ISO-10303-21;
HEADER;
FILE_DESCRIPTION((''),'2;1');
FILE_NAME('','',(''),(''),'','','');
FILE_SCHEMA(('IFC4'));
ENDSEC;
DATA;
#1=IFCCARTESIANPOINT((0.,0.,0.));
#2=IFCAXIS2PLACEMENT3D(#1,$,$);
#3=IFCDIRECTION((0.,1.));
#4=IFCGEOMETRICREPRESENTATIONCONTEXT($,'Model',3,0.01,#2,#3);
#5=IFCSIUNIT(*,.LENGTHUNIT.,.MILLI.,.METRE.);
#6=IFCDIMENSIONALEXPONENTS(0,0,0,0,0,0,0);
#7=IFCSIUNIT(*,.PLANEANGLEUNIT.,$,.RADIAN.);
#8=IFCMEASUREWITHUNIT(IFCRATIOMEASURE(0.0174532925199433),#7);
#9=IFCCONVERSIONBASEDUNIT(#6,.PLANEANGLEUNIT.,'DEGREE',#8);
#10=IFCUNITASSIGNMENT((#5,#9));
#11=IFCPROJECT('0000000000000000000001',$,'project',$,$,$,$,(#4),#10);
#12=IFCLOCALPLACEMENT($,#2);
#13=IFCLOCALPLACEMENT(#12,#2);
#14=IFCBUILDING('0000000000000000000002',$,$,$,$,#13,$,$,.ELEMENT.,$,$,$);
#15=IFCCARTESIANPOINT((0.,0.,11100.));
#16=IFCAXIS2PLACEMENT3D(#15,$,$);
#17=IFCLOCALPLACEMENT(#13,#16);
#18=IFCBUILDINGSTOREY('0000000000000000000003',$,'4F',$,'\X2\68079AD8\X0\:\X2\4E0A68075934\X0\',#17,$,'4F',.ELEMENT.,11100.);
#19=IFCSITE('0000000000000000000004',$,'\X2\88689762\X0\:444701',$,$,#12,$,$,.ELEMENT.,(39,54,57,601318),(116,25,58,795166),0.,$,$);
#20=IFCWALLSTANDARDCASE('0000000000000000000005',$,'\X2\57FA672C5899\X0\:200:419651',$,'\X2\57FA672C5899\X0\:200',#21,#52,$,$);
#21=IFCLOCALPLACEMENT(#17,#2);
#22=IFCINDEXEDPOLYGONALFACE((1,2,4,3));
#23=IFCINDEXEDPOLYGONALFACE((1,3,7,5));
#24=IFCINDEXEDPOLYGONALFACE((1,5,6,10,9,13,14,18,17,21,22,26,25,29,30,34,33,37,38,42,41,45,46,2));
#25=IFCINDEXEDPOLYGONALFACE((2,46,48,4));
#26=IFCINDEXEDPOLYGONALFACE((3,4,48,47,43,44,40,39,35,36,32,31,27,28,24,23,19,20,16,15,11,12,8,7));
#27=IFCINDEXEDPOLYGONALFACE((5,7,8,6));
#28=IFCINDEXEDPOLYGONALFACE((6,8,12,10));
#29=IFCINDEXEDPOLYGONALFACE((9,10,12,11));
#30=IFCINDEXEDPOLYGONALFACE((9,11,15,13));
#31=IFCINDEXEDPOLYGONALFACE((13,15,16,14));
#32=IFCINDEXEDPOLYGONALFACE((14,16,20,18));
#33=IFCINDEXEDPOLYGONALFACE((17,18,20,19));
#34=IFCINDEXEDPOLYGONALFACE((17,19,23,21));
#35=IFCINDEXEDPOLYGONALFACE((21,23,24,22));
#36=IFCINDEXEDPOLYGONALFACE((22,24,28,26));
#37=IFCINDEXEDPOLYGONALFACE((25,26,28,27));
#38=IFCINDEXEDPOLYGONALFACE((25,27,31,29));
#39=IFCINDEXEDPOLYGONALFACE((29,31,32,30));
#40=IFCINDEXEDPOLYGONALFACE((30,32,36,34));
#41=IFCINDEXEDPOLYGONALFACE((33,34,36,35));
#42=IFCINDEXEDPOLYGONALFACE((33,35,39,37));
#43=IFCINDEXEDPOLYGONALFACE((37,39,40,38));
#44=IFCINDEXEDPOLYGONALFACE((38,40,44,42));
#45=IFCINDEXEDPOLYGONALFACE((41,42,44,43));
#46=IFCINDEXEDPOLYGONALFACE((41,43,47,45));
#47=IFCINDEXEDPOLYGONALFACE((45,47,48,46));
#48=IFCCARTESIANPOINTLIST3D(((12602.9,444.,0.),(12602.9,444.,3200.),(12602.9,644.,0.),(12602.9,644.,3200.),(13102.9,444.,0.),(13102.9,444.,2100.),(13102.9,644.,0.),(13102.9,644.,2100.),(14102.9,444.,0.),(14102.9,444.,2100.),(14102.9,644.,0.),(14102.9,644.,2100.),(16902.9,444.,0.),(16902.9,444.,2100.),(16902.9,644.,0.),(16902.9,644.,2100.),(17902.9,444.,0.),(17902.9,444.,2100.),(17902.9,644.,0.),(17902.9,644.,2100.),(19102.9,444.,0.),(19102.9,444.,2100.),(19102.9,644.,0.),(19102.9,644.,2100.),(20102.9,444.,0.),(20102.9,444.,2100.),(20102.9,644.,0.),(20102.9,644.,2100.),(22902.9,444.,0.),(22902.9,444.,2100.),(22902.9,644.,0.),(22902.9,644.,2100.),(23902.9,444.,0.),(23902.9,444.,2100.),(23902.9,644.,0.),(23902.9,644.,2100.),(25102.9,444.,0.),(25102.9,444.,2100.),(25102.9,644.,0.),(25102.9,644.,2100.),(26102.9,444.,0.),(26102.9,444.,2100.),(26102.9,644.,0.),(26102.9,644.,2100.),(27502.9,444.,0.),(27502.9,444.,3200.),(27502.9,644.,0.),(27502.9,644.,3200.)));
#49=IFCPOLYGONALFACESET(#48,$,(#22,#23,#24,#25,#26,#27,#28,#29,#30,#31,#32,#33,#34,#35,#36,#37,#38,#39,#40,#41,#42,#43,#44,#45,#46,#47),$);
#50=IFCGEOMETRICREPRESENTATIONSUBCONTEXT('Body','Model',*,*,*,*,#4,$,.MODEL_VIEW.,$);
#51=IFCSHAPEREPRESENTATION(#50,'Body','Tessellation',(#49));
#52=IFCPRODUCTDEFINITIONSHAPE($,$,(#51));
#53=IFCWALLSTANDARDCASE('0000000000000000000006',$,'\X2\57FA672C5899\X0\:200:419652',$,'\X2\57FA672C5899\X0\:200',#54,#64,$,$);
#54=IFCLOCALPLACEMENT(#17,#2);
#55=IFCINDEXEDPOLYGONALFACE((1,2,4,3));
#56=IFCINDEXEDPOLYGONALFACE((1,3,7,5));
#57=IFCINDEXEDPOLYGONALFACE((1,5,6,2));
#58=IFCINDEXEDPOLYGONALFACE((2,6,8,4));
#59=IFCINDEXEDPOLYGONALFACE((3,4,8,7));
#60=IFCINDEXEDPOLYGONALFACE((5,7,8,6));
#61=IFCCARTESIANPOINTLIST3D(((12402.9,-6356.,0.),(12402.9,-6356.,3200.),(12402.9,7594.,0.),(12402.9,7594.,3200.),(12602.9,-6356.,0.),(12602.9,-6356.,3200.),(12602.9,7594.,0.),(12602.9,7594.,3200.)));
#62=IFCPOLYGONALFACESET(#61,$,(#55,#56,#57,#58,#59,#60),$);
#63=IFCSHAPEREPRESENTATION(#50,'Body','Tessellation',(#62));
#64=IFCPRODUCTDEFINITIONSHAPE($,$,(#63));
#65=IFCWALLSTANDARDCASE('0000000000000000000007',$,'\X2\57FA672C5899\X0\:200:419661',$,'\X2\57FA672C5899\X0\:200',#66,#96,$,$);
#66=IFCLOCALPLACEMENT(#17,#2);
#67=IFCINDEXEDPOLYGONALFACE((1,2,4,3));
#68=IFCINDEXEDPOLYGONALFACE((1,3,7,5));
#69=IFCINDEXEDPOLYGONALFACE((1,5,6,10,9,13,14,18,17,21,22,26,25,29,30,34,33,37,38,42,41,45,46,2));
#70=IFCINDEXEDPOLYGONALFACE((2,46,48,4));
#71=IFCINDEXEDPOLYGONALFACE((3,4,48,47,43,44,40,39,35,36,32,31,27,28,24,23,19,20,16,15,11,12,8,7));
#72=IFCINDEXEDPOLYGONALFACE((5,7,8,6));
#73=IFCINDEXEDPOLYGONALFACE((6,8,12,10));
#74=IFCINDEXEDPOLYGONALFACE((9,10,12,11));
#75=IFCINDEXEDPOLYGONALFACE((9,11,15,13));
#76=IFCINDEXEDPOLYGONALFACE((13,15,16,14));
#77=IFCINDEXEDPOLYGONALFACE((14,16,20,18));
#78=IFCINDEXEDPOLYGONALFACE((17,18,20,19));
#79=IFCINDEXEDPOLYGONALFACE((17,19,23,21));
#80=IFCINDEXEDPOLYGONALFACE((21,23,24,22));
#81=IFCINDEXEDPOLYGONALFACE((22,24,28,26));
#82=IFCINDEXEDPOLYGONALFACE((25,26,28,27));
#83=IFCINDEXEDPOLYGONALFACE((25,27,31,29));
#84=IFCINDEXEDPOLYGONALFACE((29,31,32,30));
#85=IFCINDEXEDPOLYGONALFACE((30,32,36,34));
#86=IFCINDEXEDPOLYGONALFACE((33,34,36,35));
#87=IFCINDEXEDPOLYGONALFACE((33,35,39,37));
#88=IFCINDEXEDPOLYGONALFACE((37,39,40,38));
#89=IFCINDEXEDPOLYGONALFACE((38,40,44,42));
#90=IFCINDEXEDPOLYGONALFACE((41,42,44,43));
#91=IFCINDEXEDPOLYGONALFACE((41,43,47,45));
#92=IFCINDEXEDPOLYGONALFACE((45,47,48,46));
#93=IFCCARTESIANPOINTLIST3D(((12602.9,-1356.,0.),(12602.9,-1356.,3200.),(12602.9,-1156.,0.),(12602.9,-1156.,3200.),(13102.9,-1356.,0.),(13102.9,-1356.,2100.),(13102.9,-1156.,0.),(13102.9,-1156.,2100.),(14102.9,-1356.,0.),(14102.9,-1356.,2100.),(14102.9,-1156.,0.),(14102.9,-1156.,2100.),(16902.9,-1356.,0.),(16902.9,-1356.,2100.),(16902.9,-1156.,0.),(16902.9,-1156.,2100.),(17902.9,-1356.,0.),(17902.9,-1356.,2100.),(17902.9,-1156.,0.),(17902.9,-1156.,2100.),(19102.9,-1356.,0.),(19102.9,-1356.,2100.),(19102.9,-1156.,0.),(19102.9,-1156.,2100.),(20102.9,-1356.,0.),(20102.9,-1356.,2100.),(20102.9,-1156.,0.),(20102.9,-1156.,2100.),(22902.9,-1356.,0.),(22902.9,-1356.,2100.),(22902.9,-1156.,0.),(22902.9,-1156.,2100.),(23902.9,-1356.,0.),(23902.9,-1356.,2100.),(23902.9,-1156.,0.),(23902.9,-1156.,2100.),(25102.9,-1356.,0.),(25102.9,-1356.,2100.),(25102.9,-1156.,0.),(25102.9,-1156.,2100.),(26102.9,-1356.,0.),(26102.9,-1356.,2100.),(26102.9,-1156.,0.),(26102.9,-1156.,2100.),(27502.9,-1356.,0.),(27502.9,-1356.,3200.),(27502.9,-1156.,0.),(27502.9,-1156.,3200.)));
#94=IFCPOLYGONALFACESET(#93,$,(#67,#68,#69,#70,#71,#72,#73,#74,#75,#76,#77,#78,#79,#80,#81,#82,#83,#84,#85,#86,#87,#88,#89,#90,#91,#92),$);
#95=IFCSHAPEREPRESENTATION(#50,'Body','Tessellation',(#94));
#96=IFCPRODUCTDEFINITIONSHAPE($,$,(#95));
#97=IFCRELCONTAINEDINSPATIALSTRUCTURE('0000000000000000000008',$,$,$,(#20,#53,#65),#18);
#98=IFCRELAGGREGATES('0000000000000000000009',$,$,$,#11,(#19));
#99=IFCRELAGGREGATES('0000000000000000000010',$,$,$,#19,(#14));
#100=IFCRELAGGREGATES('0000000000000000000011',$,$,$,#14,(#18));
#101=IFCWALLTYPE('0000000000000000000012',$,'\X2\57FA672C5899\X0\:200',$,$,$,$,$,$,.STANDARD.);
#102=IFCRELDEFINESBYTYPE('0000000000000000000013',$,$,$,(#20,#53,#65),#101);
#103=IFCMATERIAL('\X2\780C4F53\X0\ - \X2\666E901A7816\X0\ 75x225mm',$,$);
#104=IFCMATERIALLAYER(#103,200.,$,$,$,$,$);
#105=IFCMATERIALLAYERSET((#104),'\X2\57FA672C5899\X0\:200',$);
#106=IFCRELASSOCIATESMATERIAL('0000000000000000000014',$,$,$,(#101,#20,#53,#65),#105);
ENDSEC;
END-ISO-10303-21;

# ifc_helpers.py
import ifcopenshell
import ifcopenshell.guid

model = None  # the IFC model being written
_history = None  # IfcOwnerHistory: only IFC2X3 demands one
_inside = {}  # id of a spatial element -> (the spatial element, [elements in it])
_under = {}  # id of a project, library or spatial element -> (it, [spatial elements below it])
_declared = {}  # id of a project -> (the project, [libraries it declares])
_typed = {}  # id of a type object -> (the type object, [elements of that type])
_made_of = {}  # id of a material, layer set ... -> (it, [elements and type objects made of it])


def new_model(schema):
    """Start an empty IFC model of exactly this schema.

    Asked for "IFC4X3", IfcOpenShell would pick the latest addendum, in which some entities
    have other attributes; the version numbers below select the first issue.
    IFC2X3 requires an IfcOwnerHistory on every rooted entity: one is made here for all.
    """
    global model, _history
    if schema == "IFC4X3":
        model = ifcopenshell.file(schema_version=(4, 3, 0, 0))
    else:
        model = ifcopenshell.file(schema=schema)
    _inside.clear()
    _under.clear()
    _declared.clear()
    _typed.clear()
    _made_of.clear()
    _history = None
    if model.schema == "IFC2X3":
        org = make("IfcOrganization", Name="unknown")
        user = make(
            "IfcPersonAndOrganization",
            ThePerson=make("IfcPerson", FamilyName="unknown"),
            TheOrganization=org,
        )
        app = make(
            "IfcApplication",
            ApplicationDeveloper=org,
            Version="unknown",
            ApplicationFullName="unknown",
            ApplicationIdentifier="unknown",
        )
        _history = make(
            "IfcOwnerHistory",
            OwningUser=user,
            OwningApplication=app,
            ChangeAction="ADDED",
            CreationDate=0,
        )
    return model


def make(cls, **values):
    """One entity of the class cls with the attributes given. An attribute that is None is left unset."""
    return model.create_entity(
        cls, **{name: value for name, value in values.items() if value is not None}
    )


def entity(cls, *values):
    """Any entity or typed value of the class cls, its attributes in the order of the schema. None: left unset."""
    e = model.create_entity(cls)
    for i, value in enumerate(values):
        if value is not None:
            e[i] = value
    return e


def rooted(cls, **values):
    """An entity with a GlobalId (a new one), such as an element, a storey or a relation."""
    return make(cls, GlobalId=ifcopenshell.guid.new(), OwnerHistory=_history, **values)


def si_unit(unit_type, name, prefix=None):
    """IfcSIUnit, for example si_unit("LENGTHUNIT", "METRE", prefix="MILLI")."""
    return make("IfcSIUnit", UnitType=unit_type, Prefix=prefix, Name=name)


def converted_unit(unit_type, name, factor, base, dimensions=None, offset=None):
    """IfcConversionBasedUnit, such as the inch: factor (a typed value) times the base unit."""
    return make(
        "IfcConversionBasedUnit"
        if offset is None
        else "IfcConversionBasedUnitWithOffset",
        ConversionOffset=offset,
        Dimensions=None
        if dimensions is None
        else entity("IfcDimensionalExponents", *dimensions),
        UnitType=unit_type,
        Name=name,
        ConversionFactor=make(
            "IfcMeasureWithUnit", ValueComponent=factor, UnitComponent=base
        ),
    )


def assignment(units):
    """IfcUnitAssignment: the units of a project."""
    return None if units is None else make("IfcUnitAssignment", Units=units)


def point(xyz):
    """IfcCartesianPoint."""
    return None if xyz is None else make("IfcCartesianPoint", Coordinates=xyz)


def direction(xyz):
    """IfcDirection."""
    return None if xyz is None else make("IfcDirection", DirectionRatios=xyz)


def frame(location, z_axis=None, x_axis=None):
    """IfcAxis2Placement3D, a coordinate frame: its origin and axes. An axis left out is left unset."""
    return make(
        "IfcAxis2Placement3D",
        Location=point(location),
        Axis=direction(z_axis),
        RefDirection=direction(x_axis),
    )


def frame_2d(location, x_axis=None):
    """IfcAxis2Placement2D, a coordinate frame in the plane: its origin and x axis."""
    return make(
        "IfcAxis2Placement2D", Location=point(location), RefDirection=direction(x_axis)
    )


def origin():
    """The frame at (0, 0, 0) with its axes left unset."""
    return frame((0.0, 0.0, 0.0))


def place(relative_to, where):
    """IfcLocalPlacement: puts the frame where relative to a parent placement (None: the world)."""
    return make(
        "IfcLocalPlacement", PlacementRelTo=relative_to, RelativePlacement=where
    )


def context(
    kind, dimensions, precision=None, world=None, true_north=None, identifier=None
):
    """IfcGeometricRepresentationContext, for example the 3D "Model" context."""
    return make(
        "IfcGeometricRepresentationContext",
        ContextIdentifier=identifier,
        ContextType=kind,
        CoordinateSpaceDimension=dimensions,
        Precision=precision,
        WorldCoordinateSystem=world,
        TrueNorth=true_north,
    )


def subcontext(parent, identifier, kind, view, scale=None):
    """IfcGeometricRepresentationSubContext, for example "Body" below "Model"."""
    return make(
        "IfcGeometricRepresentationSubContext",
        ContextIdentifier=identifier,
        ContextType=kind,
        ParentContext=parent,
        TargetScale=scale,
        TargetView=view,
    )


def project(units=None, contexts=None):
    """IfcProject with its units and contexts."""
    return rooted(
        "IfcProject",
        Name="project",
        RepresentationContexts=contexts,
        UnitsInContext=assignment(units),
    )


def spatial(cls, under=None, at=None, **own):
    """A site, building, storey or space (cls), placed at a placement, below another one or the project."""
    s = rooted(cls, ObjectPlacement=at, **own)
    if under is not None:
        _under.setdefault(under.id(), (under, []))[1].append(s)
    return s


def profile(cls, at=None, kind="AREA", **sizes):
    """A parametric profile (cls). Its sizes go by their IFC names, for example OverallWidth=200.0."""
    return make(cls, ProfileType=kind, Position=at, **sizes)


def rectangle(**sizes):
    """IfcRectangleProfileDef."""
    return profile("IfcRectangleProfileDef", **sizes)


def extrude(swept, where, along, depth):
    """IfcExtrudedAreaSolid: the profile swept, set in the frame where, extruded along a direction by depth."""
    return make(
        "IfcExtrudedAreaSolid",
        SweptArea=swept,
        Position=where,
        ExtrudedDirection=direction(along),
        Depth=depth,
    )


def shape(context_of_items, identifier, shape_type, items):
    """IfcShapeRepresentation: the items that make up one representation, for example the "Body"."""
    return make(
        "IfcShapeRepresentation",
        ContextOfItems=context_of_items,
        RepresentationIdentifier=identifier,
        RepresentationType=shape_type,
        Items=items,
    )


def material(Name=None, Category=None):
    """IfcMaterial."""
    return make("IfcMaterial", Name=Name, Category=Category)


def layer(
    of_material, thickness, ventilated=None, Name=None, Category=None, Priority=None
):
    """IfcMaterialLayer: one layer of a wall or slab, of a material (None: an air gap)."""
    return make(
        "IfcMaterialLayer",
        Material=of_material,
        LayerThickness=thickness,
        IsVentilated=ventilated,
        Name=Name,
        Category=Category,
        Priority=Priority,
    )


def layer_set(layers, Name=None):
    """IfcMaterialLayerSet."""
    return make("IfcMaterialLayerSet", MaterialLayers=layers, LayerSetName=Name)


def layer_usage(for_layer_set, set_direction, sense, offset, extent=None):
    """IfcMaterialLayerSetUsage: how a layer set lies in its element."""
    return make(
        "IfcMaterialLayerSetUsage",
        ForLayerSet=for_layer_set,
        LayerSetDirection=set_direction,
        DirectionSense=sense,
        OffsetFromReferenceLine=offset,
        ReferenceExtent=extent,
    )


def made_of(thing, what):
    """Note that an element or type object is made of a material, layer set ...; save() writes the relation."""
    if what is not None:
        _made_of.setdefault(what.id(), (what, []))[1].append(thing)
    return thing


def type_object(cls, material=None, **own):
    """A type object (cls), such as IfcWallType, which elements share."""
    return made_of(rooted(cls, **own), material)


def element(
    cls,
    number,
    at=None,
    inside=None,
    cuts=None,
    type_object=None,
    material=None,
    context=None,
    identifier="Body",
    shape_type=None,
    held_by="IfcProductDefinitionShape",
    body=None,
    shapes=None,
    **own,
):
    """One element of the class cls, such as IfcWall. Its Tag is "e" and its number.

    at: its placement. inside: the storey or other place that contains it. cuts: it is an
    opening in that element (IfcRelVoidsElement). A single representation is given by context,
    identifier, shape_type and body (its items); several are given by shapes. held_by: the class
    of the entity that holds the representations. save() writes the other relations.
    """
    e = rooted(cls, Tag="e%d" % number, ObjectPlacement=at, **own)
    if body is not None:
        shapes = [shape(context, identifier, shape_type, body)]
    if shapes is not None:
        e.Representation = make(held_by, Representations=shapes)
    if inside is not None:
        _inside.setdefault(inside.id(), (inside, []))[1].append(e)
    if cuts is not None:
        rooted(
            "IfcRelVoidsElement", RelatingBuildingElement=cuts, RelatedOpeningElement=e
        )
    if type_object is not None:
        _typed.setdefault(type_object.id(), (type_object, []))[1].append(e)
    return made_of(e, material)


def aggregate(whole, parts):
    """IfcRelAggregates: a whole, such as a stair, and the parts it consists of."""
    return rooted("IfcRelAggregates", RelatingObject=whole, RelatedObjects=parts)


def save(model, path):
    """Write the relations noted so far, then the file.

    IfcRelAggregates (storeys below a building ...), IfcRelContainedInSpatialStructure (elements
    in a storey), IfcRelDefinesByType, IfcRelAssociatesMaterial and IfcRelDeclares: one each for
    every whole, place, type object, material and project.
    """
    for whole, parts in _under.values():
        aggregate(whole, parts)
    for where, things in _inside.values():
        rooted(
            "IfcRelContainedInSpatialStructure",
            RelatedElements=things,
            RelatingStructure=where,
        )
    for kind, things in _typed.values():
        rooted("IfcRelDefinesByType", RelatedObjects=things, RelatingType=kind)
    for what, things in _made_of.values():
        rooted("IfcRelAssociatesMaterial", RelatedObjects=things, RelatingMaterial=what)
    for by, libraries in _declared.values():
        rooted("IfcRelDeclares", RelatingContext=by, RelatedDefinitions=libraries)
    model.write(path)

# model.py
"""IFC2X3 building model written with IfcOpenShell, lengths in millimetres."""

from ifc_helpers import new_model, entity, si_unit, converted_unit, direction, frame, frame_2d, origin, place, context, subcontext, project, spatial, rectangle, extrude, material, layer, layer_set, layer_usage, type_object, element, save


model = new_model("IFC2X3")

# Units and contexts
model_context = context("Model", 3, precision=0.01, world=origin(), true_north=direction((0.0, 1.0)))
body_context = subcontext(model_context, "Body", "Model", "MODEL_VIEW")
ifc_project = project(units=[si_unit("LENGTHUNIT", "METRE", prefix="MILLI"), converted_unit("PLANEANGLEUNIT", "DEGREE", entity("IfcRatioMeasure", 0.0174532925199433), si_unit("PLANEANGLEUNIT", "RADIAN"), dimensions=[0, 0, 0, 0, 0, 0, 0])], contexts=[model_context])

# Site, building, storey
site_placement = place(None, origin())
site = spatial("IfcSite", under=ifc_project, at=site_placement, Name="表面:444701", CompositionType="ELEMENT", RefLatitude=(39, 54, 57, 601318), RefLongitude=(116, 25, 58, 795166), RefElevation=0.0)
building_placement = place(site_placement, origin())
building = spatial("IfcBuilding", under=site, at=building_placement, CompositionType="ELEMENT")
storey_placement = place(building_placement, frame((0.0, 0.0, 11100.0)))
storey = spatial("IfcBuildingStorey", under=building, at=storey_placement, Name="4F", ObjectType="标高:上标头", LongName="4F", CompositionType="ELEMENT", Elevation=11100.0)

# Shared definitions
ifc_material_1 = material(Name="砌体 - 普通砖 75x225mm")

# Wall, openings
ifc_layer_1 = layer(ifc_material_1, 200.0)
ifc_layer_set_1 = layer_set([ifc_layer_1], Name="基本墙:200")
ifc_layer_usage_1 = layer_usage(ifc_layer_set_1, "AXIS2", "NEGATIVE", 100.0)
wall_type_1 = type_object("IfcWallType", Name="基本墙:200", PredefinedType="STANDARD", material=ifc_layer_set_1)
wall_1_placement = place(storey_placement, frame((12602.9, 544.0, 0.0)))
wall_1 = element("IfcWallStandardCase", 1, at=wall_1_placement, inside=storey, type_object=wall_type_1, material=ifc_layer_usage_1, Name="基本墙:200:419651", ObjectType="基本墙:200", context=body_context, shape_type="SweptSolid", body=[
    extrude(rectangle(XDim=14900.0, YDim=200.0, at=frame_2d((7450.0, 0.0), x_axis=(-1.0, 0.0))), origin(), (0.0, 0.0, 1.0), 3200.0),
])
opening_1_placement = place(wall_1_placement, frame((12500.0, -100.0, 0.0)))
element("IfcOpeningElement", 2, at=opening_1_placement, cuts=wall_1, ObjectType="Opening", context=body_context, shape_type="SweptSolid", body=[
    extrude(rectangle(XDim=2100.0, YDim=1000.0, at=frame_2d((1050.0, 500.0), x_axis=(1.0, 0.0))), frame((0.0, 0.0, 0.0), z_axis=(0.0, 1.0, 0.0), x_axis=(0.0, 0.0, 1.0)), (0.0, 0.0, 1.0), 200.0),
])
opening_2_placement = place(wall_1_placement, frame((10300.0, -100.0, 0.0)))
element("IfcOpeningElement", 3, at=opening_2_placement, cuts=wall_1, ObjectType="Opening", context=body_context, shape_type="SweptSolid", body=[
    extrude(rectangle(XDim=2100.0, YDim=1000.0, at=frame_2d((1050.0, 500.0), x_axis=(1.0, 0.0))), frame((0.0, 0.0, 0.0), z_axis=(0.0, 1.0, 0.0), x_axis=(0.0, 0.0, 1.0)), (0.0, 0.0, 1.0), 200.0),
])
opening_3_placement = place(wall_1_placement, frame((6500.0, -100.0, 0.0)))
element("IfcOpeningElement", 4, at=opening_3_placement, cuts=wall_1, ObjectType="Opening", context=body_context, shape_type="SweptSolid", body=[
    extrude(rectangle(XDim=2100.0, YDim=1000.0, at=frame_2d((1050.0, 500.0), x_axis=(1.0, 0.0))), frame((0.0, 0.0, 0.0), z_axis=(0.0, 1.0, 0.0), x_axis=(0.0, 0.0, 1.0)), (0.0, 0.0, 1.0), 200.0),
])
opening_4_placement = place(wall_1_placement, frame((4300.0, -100.0, 0.0)))
element("IfcOpeningElement", 5, at=opening_4_placement, cuts=wall_1, ObjectType="Opening", context=body_context, shape_type="SweptSolid", body=[
    extrude(rectangle(XDim=2100.0, YDim=1000.0, at=frame_2d((1050.0, 500.0), x_axis=(1.0, 0.0))), frame((0.0, 0.0, 0.0), z_axis=(0.0, 1.0, 0.0), x_axis=(0.0, 0.0, 1.0)), (0.0, 0.0, 1.0), 200.0),
])
opening_5_placement = place(wall_1_placement, frame((500.0, -100.0, 0.0)))
element("IfcOpeningElement", 6, at=opening_5_placement, cuts=wall_1, ObjectType="Opening", context=body_context, shape_type="SweptSolid", body=[
    extrude(rectangle(XDim=2100.0, YDim=1000.0, at=frame_2d((1050.0, 500.0), x_axis=(1.0, 0.0))), frame((0.0, 0.0, 0.0), z_axis=(0.0, 1.0, 0.0), x_axis=(0.0, 0.0, 1.0)), (0.0, 0.0, 1.0), 200.0),
])

# Wall
ifc_layer_usage_2 = layer_usage(ifc_layer_set_1, "AXIS2", "NEGATIVE", 100.0)
wall_2_placement = place(storey_placement, frame((12502.9, -6356.0, 0.0), z_axis=(0.0, 0.0, 1.0), x_axis=(0.0, 1.0, 0.0)))
element("IfcWallStandardCase", 7, at=wall_2_placement, inside=storey, type_object=wall_type_1, material=ifc_layer_usage_2, Name="基本墙:200:419652", ObjectType="基本墙:200", context=body_context, shape_type="SweptSolid", body=[
    extrude(rectangle(XDim=13950.0, YDim=200.0, at=frame_2d((6975.0, 0.0), x_axis=(-1.0, 0.0))), origin(), (0.0, 0.0, 1.0), 3200.0),
])

# Wall, openings
ifc_layer_usage_3 = layer_usage(ifc_layer_set_1, "AXIS2", "NEGATIVE", 100.0)
wall_3_placement = place(storey_placement, frame((12602.9, -1256.0, 0.0)))
wall_3 = element("IfcWallStandardCase", 8, at=wall_3_placement, inside=storey, type_object=wall_type_1, material=ifc_layer_usage_3, Name="基本墙:200:419661", ObjectType="基本墙:200", context=body_context, shape_type="SweptSolid", body=[
    extrude(rectangle(XDim=14900.0, YDim=200.0, at=frame_2d((7450.0, 0.0), x_axis=(-1.0, 0.0))), origin(), (0.0, 0.0, 1.0), 3200.0),
])
opening_6_placement = place(wall_3_placement, frame((13500.0, 100.0, 0.0)))
element("IfcOpeningElement", 9, at=opening_6_placement, cuts=wall_3, ObjectType="Opening", context=body_context, shape_type="SweptSolid", body=[
    extrude(rectangle(XDim=2100.0, YDim=1000.0, at=frame_2d((1050.0, 500.0), x_axis=(1.0, 0.0))), frame((0.0, 0.0, 0.0), z_axis=(0.0, -1.0, 0.0), x_axis=(0.0, 0.0, 1.0)), (0.0, 0.0, 1.0), 200.0),
])
opening_7_placement = place(wall_3_placement, frame((11300.0, 100.0, 0.0)))
element("IfcOpeningElement", 10, at=opening_7_placement, cuts=wall_3, ObjectType="Opening", context=body_context, shape_type="SweptSolid", body=[
    extrude(rectangle(XDim=2100.0, YDim=1000.0, at=frame_2d((1050.0, 500.0), x_axis=(1.0, 0.0))), frame((0.0, 0.0, 0.0), z_axis=(0.0, -1.0, 0.0), x_axis=(0.0, 0.0, 1.0)), (0.0, 0.0, 1.0), 200.0),
])
opening_8_placement = place(wall_3_placement, frame((7500.0, 100.0, 0.0)))
element("IfcOpeningElement", 11, at=opening_8_placement, cuts=wall_3, ObjectType="Opening", context=body_context, shape_type="SweptSolid", body=[
    extrude(rectangle(XDim=2100.0, YDim=1000.0, at=frame_2d((1050.0, 500.0), x_axis=(1.0, 0.0))), frame((0.0, 0.0, 0.0), z_axis=(0.0, -1.0, 0.0), x_axis=(0.0, 0.0, 1.0)), (0.0, 0.0, 1.0), 200.0),
])
opening_9_placement = place(wall_3_placement, frame((5300.0, 100.0, 0.0)))
element("IfcOpeningElement", 12, at=opening_9_placement, cuts=wall_3, ObjectType="Opening", context=body_context, shape_type="SweptSolid", body=[
    extrude(rectangle(XDim=2100.0, YDim=1000.0, at=frame_2d((1050.0, 500.0), x_axis=(1.0, 0.0))), frame((0.0, 0.0, 0.0), z_axis=(0.0, -1.0, 0.0), x_axis=(0.0, 0.0, 1.0)), (0.0, 0.0, 1.0), 200.0),
])
opening_10_placement = place(wall_3_placement, frame((1500.0, 100.0, 0.0)))
element("IfcOpeningElement", 13, at=opening_10_placement, cuts=wall_3, ObjectType="Opening", context=body_context, shape_type="SweptSolid", body=[
    extrude(rectangle(XDim=2100.0, YDim=1000.0, at=frame_2d((1050.0, 500.0), x_axis=(1.0, 0.0))), frame((0.0, 0.0, 0.0), z_axis=(0.0, -1.0, 0.0), x_axis=(0.0, 0.0, 1.0)), (0.0, 0.0, 1.0), 200.0),
])

save(model, "model.ifc")
